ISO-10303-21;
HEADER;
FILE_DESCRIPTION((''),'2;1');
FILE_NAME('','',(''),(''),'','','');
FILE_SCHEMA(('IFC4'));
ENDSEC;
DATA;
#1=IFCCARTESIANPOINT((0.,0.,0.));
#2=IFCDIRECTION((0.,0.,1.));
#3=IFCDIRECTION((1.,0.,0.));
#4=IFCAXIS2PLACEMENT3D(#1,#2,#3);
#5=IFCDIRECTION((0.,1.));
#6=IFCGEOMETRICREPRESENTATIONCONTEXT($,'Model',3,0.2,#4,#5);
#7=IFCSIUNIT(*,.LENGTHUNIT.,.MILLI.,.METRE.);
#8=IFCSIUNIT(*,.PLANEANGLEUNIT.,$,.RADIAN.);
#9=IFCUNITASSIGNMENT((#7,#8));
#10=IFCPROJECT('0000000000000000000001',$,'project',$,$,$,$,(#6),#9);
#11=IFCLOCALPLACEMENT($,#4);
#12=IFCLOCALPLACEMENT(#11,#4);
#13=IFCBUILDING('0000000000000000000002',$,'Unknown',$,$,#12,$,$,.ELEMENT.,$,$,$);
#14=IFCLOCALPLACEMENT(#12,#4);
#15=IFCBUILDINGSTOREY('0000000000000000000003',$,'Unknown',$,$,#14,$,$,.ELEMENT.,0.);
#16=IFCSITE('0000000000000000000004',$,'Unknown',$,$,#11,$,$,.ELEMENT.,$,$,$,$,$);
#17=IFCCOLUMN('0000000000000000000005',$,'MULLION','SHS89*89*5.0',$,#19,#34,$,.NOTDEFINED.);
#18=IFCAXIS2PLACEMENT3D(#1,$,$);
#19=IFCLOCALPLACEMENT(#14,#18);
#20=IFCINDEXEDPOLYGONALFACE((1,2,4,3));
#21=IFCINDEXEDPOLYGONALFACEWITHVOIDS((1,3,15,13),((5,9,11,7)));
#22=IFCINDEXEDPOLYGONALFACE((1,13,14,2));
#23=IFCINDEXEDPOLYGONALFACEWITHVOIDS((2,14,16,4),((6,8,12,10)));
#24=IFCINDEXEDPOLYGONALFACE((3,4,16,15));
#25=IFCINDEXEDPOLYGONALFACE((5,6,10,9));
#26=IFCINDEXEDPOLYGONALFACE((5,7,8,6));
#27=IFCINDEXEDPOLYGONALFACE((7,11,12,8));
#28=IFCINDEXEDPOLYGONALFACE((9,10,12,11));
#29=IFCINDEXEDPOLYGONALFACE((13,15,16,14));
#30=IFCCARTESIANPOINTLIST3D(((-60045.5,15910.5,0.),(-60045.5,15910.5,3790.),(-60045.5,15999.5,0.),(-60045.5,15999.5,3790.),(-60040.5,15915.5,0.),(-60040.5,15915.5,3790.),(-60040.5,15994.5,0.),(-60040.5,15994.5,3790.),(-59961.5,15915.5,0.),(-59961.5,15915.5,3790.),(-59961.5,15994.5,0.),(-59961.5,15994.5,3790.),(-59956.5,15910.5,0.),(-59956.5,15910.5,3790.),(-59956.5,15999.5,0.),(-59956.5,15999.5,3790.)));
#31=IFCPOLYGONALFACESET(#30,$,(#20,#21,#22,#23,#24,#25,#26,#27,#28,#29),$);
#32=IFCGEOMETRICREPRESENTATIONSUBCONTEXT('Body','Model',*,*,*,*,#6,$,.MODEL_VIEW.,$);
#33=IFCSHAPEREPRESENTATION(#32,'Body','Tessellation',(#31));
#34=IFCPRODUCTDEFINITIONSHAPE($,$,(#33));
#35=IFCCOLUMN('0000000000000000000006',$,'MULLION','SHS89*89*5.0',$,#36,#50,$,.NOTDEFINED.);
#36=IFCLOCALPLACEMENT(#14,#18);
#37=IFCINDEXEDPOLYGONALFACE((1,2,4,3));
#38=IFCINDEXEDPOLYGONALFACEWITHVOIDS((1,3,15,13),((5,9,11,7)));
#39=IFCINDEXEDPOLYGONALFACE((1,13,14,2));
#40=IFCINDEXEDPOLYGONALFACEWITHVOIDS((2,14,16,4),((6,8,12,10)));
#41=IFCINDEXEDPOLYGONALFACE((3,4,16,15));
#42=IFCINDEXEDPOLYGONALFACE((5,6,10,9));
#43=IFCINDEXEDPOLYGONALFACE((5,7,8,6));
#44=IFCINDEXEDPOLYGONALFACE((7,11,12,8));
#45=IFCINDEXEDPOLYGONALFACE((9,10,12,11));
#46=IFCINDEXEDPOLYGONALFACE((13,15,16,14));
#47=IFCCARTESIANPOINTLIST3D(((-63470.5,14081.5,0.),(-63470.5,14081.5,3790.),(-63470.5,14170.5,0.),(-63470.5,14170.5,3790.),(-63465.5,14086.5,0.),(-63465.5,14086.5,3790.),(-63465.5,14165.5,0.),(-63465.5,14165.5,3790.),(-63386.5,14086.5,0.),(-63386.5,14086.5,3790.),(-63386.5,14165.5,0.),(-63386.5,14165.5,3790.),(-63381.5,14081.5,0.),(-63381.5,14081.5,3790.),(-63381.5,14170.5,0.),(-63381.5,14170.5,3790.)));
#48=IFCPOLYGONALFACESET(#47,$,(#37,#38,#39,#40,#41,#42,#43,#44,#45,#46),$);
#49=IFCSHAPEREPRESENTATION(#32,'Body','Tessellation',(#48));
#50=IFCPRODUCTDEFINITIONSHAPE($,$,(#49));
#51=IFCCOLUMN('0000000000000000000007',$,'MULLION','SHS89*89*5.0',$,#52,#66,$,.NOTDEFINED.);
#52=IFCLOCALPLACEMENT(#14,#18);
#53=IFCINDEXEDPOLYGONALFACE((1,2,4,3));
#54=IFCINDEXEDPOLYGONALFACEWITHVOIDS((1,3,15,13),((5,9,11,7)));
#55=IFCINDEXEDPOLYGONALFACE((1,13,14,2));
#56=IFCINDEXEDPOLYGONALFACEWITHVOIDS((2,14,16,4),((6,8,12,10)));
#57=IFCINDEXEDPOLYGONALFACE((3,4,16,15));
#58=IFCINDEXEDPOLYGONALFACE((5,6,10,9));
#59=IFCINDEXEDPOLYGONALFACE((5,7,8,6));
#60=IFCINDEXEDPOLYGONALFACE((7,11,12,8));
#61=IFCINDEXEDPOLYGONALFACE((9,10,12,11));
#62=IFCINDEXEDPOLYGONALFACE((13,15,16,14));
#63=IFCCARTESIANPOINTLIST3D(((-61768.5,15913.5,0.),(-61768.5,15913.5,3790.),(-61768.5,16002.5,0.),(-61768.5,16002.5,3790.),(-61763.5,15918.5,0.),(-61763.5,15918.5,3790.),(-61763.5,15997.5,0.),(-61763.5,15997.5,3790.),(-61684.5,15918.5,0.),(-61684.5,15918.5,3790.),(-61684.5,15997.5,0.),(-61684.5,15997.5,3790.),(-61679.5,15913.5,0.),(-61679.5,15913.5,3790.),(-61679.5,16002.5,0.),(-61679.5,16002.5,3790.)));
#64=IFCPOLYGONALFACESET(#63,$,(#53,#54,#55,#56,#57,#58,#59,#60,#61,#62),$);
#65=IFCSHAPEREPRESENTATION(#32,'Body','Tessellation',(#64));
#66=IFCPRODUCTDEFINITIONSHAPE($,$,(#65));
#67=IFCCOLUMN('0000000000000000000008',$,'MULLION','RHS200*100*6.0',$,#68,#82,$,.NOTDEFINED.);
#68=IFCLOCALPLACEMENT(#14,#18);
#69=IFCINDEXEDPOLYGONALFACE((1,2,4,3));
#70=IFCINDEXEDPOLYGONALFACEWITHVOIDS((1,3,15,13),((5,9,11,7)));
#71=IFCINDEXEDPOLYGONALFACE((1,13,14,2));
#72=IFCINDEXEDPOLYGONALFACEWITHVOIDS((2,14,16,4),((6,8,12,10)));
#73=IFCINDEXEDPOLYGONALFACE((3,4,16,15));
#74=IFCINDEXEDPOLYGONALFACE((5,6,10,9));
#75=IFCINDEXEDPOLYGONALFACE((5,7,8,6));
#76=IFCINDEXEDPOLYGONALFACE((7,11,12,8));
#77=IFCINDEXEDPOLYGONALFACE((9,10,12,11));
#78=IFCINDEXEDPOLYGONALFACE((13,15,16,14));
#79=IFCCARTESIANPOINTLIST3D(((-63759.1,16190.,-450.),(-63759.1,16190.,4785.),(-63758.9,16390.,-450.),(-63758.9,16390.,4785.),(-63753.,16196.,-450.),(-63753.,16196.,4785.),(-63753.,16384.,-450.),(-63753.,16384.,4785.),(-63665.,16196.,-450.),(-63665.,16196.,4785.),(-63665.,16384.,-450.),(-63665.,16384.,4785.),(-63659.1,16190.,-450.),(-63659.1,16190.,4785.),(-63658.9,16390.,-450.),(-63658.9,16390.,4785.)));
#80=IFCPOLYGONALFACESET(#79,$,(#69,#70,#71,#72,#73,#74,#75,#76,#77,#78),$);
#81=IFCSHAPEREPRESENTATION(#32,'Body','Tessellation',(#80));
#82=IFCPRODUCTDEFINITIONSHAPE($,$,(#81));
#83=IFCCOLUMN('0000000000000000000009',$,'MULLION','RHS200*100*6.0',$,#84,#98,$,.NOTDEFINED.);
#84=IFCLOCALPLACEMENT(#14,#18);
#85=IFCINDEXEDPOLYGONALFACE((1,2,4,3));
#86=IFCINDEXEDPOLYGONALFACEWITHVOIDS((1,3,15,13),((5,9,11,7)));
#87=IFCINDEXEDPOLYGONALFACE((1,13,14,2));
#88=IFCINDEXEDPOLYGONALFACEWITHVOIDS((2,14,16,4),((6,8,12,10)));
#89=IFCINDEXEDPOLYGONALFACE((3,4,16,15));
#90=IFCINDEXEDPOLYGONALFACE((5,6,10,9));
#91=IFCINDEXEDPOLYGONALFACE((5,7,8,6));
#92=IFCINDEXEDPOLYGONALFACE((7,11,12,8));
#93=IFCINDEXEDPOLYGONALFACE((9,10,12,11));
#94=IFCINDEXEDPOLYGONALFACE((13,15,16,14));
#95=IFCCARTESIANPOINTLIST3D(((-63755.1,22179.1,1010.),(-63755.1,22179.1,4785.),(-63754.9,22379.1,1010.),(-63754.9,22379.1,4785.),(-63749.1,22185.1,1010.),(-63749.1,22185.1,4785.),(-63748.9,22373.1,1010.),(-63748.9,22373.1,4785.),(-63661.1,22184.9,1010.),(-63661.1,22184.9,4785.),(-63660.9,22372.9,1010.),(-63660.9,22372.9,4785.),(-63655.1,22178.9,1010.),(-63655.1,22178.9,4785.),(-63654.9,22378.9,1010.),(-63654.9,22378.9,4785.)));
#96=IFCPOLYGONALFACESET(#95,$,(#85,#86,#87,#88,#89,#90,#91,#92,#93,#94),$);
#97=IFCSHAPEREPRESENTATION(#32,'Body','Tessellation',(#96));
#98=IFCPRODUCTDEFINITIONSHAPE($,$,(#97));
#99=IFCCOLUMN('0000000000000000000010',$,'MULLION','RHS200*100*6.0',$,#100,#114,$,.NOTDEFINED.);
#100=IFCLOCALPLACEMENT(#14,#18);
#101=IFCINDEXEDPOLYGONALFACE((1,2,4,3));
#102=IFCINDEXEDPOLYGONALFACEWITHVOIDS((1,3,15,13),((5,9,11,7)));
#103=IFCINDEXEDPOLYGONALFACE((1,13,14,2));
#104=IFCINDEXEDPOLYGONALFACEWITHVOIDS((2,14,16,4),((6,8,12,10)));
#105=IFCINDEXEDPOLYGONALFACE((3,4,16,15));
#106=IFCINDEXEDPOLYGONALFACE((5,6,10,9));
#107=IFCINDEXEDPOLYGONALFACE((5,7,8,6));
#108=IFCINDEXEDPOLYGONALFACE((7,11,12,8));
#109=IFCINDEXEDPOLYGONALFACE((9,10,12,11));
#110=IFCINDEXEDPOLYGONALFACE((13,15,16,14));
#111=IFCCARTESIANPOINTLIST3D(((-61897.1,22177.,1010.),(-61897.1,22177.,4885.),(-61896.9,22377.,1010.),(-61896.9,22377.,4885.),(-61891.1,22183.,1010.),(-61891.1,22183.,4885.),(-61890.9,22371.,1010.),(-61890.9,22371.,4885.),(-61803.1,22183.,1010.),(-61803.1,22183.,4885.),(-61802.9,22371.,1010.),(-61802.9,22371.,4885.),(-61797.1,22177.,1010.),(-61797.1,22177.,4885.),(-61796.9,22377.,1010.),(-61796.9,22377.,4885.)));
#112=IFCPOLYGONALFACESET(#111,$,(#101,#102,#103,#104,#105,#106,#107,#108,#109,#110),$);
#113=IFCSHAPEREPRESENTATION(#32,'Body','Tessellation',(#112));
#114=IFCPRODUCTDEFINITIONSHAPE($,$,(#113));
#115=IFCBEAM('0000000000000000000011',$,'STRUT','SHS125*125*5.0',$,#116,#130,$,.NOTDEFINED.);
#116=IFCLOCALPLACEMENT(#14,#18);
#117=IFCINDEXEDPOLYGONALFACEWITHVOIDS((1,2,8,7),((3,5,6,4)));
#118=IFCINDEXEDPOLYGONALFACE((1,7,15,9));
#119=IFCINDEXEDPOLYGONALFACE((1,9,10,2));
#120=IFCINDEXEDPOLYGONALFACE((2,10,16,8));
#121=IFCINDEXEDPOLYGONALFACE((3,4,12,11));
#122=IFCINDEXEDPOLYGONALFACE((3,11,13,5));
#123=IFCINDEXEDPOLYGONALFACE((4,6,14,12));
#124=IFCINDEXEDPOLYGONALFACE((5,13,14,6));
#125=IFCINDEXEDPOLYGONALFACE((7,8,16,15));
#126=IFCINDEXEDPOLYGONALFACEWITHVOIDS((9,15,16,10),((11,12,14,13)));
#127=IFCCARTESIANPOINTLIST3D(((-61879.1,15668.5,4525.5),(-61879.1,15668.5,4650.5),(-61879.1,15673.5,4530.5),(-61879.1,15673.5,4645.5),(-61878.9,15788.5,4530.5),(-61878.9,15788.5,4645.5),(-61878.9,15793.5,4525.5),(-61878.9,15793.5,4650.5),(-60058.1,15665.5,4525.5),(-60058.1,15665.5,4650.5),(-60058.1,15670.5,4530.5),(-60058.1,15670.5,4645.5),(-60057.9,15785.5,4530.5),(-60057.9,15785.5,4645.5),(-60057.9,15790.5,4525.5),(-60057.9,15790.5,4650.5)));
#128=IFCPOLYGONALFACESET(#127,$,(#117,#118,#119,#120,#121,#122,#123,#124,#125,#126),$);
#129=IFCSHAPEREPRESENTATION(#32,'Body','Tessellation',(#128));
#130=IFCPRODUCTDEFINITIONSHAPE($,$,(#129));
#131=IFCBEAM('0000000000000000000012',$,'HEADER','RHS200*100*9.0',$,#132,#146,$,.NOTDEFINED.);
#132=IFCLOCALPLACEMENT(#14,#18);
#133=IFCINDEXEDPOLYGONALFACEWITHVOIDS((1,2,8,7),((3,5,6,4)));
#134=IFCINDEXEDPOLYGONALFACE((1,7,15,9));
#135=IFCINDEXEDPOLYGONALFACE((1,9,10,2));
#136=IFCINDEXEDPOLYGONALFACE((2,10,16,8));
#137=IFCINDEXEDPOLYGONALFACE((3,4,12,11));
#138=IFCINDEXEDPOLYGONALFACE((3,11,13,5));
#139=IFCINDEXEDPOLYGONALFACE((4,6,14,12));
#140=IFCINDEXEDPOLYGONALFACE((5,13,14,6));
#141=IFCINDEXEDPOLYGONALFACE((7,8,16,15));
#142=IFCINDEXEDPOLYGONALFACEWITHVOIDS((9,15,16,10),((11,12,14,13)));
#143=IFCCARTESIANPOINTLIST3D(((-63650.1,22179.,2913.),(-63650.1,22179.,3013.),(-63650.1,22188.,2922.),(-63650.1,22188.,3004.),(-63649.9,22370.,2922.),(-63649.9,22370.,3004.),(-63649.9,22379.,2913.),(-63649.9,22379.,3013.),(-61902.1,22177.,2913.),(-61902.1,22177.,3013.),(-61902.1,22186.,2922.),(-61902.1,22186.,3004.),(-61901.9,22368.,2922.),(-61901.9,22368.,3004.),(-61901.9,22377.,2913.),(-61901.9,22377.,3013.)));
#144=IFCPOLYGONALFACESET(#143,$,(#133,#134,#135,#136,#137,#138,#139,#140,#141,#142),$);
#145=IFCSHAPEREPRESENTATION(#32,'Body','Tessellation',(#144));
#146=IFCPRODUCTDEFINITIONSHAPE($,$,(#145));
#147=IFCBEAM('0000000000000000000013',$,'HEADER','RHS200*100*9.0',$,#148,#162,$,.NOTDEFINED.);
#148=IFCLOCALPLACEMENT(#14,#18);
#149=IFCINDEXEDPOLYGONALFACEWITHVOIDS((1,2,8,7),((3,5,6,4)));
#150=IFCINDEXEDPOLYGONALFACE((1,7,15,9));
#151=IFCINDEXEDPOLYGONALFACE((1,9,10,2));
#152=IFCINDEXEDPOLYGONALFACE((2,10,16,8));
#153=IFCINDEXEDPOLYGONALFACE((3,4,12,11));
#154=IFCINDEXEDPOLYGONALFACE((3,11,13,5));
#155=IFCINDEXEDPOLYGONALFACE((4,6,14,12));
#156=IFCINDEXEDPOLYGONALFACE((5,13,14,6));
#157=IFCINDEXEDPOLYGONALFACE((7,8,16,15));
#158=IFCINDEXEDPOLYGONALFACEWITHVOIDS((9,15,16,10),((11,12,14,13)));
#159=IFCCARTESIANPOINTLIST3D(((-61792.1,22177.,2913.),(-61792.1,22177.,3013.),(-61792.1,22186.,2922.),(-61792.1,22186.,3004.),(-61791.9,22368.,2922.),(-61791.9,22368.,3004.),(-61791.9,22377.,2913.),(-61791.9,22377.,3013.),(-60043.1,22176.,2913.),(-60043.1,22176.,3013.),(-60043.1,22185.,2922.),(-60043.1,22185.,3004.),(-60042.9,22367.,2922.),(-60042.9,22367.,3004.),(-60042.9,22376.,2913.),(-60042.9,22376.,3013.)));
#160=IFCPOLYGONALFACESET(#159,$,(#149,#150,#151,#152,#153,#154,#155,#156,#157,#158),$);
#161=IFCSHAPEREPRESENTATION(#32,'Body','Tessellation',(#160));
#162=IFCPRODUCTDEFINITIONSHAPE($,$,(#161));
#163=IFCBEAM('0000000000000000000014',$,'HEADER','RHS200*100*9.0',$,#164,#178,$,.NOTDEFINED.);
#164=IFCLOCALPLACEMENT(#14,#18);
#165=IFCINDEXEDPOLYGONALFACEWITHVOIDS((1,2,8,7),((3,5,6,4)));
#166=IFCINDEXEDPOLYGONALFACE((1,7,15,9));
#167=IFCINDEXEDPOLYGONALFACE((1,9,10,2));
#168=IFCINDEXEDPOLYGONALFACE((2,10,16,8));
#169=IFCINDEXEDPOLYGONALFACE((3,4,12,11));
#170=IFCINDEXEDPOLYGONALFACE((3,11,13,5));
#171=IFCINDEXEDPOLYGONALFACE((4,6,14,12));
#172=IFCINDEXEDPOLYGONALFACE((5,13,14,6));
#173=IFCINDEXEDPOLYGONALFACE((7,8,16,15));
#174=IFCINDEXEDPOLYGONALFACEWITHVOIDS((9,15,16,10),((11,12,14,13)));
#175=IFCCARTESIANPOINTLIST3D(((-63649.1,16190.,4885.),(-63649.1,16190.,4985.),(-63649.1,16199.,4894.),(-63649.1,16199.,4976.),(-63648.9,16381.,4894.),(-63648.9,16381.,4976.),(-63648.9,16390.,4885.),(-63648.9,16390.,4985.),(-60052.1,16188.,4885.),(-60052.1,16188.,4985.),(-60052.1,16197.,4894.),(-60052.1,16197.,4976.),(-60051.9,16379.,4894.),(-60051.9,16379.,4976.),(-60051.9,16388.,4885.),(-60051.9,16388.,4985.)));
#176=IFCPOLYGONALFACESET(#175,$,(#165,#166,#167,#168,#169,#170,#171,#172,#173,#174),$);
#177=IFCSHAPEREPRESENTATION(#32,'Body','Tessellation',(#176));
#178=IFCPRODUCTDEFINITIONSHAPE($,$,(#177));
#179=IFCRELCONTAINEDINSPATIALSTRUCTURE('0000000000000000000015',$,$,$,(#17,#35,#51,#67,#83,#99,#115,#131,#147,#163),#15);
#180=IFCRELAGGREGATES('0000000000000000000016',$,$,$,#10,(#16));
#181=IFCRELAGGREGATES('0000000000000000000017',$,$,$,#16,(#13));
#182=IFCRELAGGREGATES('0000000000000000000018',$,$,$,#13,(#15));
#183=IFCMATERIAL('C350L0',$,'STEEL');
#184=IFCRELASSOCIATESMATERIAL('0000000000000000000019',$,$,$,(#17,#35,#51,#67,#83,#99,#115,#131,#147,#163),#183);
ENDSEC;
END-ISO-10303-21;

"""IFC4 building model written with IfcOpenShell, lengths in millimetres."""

from ifc_helpers import new_model, si_unit, direction, frame, origin_with_axes, place, context, subcontext, project, spatial, line, indexed_curve, outline, extrude, material, element, save


model = new_model("IFC4")

# Units and contexts
model_context = context("Model", 3, precision=0.2, world=origin_with_axes(), true_north=direction((0.0, 1.0)))
body_context = subcontext(model_context, "Body", "Model", "MODEL_VIEW")
ifc_project = project(units=[si_unit("LENGTHUNIT", "METRE", prefix="MILLI"), si_unit("PLANEANGLEUNIT", "RADIAN")], contexts=[model_context])

# Site, building, storey
site_placement = place(None, origin_with_axes())
site = spatial("IfcSite", under=ifc_project, at=site_placement, Name="Unknown", CompositionType="ELEMENT")
building_placement = place(site_placement, origin_with_axes())
building = spatial("IfcBuilding", under=site, at=building_placement, Name="Unknown", CompositionType="ELEMENT")
storey_placement = place(building_placement, origin_with_axes())
storey = spatial("IfcBuildingStorey", under=building, at=storey_placement, Name="Unknown", CompositionType="ELEMENT", Elevation=0.0)

# Columns
ifc_material_1 = material(Name="C350L0", Category="STEEL")
for number, where, z_axis, x_axis, name in (
    (1, (-60001.0, 15955.0, 0.0), (0.000017, -1.0, 0.0), (0.0, 0.0, 1.0), "MULLION"),
    (2, (-63426.0, 14126.0, 0.0), (0.000017, -1.0, 0.0), (0.0, 0.0, 1.0), "MULLION"),
    (3, (-61724.0, 15958.0, 0.0), (0.000017, -1.0, 0.0), (0.0, 0.0, 1.0), "MULLION"),
):
    element("IfcColumn", number, at=place(storey_placement, frame(where, z_axis=z_axis, x_axis=x_axis)), inside=storey, material=ifc_material_1, Name=name, Description="SHS89*89*5.0", PredefinedType="NOTDEFINED", context=body_context, shape_type="SolidModel", body=[
        extrude(outline(indexed_curve([(-44.5, -44.5), (44.5, -44.5), (44.5, 44.5), (-44.5, 44.5)], segments=[line(1, 2, 3, 4, 1)]), holes=[indexed_curve([(-39.5, -39.5), (-39.5, 39.5), (39.5, 39.5), (39.5, -39.5)], segments=[line(1, 2, 3, 4, 1)])]), frame((0.0, 0.0, 0.0), z_axis=(-1.0, 0.0, 0.0), x_axis=(0.0, 0.0, 1.0)), (0.0, 0.0, -1.0), 3790.0),
    ])
column_1_placement = place(storey_placement, frame((-63709.0, 16290.0, -450.0), z_axis=(1.0, -0.000524, 0.0), x_axis=(0.0, 0.0, 1.0)))
element("IfcColumn", 4, at=column_1_placement, inside=storey, material=ifc_material_1, Name="MULLION", Description="RHS200*100*6.0", PredefinedType="NOTDEFINED", context=body_context, shape_type="SolidModel", body=[
    extrude(outline(indexed_curve([(-50.0, -100.0), (50.0, -100.0), (50.0, 100.0), (-50.0, 100.0)], segments=[line(1, 2, 3, 4, 1)]), holes=[indexed_curve([(-44.0, -94.0), (-44.0, 94.0), (44.0, 94.0), (44.0, -94.0)], segments=[line(1, 2, 3, 4, 1)])]), frame((0.0, 0.0, 0.0), z_axis=(-1.0, 0.0, 0.0), x_axis=(0.0, 0.0, 1.0)), (0.0, 0.0, -1.0), 5235.0),
])
column_2_placement = place(storey_placement, frame((-63705.0, 22279.0, 1010.0), z_axis=(0.999999, -0.001222, 0.0), x_axis=(0.0, 0.0, 1.0)))
element("IfcColumn", 5, at=column_2_placement, inside=storey, material=ifc_material_1, Name="MULLION", Description="RHS200*100*6.0", PredefinedType="NOTDEFINED", context=body_context, shape_type="SolidModel", body=[
    extrude(outline(indexed_curve([(-50.0, -100.0), (50.0, -100.0), (50.0, 100.0), (-50.0, 100.0)], segments=[line(1, 2, 3, 4, 1)]), holes=[indexed_curve([(-44.0, -94.0), (-44.0, 94.0), (44.0, 94.0), (44.0, -94.0)], segments=[line(1, 2, 3, 4, 1)])]), frame((0.0, 0.0, 0.0), z_axis=(-1.0, 0.0, 0.0), x_axis=(0.0, 0.0, 1.0)), (0.0, 0.0, -1.0), 3775.0),
])
column_3_placement = place(storey_placement, frame((-61847.0, 22277.0, 1010.0), z_axis=(1.0, -0.000873, 0.0), x_axis=(0.0, 0.0, 1.0)))
element("IfcColumn", 6, at=column_3_placement, inside=storey, material=ifc_material_1, Name="MULLION", Description="RHS200*100*6.0", PredefinedType="NOTDEFINED", context=body_context, shape_type="SolidModel", body=[
    extrude(outline(indexed_curve([(-50.0, -100.0), (50.0, -100.0), (50.0, 100.0), (-50.0, 100.0)], segments=[line(1, 2, 3, 4, 1)]), holes=[indexed_curve([(-44.0, -94.0), (-44.0, 94.0), (44.0, 94.0), (44.0, -94.0)], segments=[line(1, 2, 3, 4, 1)])]), frame((0.0, 0.0, 0.0), z_axis=(-1.0, 0.0, 0.0), x_axis=(0.0, 0.0, 1.0)), (0.0, 0.0, -1.0), 3875.0),
])

# Beams
beam_1_placement = place(storey_placement, frame((-61879.0, 15731.0, 4588.0), z_axis=(0.0, 0.0, 1.0), x_axis=(0.999999, -0.001647, 0.0)))
element("IfcBeam", 7, at=beam_1_placement, inside=storey, material=ifc_material_1, Name="STRUT", Description="SHS125*125*5.0", PredefinedType="NOTDEFINED", context=body_context, shape_type="SolidModel", body=[
    extrude(outline(indexed_curve([(-62.5, -62.5), (62.5, -62.5), (62.5, 62.5), (-62.5, 62.5)], segments=[line(1, 2, 3, 4, 1)]), holes=[indexed_curve([(-57.5, -57.5), (-57.5, 57.5), (57.5, 57.5), (57.5, -57.5)], segments=[line(1, 2, 3, 4, 1)])]), frame((0.0, 0.0, 0.0), z_axis=(-1.0, 0.0, 0.0), x_axis=(0.0, 0.0, 1.0)), (0.0, 0.0, -1.0), 1821.0),
])
beam_2_placement = place(storey_placement, frame((-61902.0, 22277.0, 2963.0), z_axis=(0.0, 0.0, 1.0), x_axis=(-0.999999, 0.001144, 0.0)))
element("IfcBeam", 8, at=beam_2_placement, inside=storey, material=ifc_material_1, Name="HEADER", Description="RHS200*100*9.0", PredefinedType="NOTDEFINED", context=body_context, shape_type="SolidModel", body=[
    extrude(outline(indexed_curve([(-50.0, -100.0), (50.0, -100.0), (50.0, 100.0), (-50.0, 100.0)], segments=[line(1, 2, 3, 4, 1)]), holes=[indexed_curve([(-41.0, -91.0), (-41.0, 91.0), (41.0, 91.0), (41.0, -91.0)], segments=[line(1, 2, 3, 4, 1)])]), frame((0.0, 0.0, 0.0), z_axis=(-1.0, 0.0, 0.0), x_axis=(0.0, 0.0, 1.0)), (0.0, 0.0, -1.0), 1748.0),
])
beam_3_placement = place(storey_placement, frame((-60043.0, 22276.0, 2963.0), z_axis=(0.0, 0.0, 1.0), x_axis=(-1.0, 0.000572, 0.0)))
element("IfcBeam", 9, at=beam_3_placement, inside=storey, material=ifc_material_1, Name="HEADER", Description="RHS200*100*9.0", PredefinedType="NOTDEFINED", context=body_context, shape_type="SolidModel", body=[
    extrude(outline(indexed_curve([(-50.0, -100.0), (50.0, -100.0), (50.0, 100.0), (-50.0, 100.0)], segments=[line(1, 2, 3, 4, 1)]), holes=[indexed_curve([(-41.0, -91.0), (-41.0, 91.0), (41.0, 91.0), (41.0, -91.0)], segments=[line(1, 2, 3, 4, 1)])]), frame((0.0, 0.0, 0.0), z_axis=(-1.0, 0.0, 0.0), x_axis=(0.0, 0.0, 1.0)), (0.0, 0.0, -1.0), 1749.0),
])
beam_4_placement = place(storey_placement, frame((-60052.0, 16288.0, 4935.0), z_axis=(0.0, 0.0, 1.0), x_axis=(-1.0, 0.000556, 0.0)))
element("IfcBeam", 10, at=beam_4_placement, inside=storey, material=ifc_material_1, Name="HEADER", Description="RHS200*100*9.0", PredefinedType="NOTDEFINED", context=body_context, shape_type="SolidModel", body=[
    extrude(outline(indexed_curve([(-50.0, -100.0), (50.0, -100.0), (50.0, 100.0), (-50.0, 100.0)], segments=[line(1, 2, 3, 4, 1)]), holes=[indexed_curve([(-41.0, -91.0), (-41.0, 91.0), (41.0, 91.0), (41.0, -91.0)], segments=[line(1, 2, 3, 4, 1)])]), frame((0.0, 0.0, 0.0), z_axis=(-1.0, 0.0, 0.0), x_axis=(0.0, 0.0, 1.0)), (0.0, 0.0, -1.0), 3597.0),
])

save(model, "model.ifc")
